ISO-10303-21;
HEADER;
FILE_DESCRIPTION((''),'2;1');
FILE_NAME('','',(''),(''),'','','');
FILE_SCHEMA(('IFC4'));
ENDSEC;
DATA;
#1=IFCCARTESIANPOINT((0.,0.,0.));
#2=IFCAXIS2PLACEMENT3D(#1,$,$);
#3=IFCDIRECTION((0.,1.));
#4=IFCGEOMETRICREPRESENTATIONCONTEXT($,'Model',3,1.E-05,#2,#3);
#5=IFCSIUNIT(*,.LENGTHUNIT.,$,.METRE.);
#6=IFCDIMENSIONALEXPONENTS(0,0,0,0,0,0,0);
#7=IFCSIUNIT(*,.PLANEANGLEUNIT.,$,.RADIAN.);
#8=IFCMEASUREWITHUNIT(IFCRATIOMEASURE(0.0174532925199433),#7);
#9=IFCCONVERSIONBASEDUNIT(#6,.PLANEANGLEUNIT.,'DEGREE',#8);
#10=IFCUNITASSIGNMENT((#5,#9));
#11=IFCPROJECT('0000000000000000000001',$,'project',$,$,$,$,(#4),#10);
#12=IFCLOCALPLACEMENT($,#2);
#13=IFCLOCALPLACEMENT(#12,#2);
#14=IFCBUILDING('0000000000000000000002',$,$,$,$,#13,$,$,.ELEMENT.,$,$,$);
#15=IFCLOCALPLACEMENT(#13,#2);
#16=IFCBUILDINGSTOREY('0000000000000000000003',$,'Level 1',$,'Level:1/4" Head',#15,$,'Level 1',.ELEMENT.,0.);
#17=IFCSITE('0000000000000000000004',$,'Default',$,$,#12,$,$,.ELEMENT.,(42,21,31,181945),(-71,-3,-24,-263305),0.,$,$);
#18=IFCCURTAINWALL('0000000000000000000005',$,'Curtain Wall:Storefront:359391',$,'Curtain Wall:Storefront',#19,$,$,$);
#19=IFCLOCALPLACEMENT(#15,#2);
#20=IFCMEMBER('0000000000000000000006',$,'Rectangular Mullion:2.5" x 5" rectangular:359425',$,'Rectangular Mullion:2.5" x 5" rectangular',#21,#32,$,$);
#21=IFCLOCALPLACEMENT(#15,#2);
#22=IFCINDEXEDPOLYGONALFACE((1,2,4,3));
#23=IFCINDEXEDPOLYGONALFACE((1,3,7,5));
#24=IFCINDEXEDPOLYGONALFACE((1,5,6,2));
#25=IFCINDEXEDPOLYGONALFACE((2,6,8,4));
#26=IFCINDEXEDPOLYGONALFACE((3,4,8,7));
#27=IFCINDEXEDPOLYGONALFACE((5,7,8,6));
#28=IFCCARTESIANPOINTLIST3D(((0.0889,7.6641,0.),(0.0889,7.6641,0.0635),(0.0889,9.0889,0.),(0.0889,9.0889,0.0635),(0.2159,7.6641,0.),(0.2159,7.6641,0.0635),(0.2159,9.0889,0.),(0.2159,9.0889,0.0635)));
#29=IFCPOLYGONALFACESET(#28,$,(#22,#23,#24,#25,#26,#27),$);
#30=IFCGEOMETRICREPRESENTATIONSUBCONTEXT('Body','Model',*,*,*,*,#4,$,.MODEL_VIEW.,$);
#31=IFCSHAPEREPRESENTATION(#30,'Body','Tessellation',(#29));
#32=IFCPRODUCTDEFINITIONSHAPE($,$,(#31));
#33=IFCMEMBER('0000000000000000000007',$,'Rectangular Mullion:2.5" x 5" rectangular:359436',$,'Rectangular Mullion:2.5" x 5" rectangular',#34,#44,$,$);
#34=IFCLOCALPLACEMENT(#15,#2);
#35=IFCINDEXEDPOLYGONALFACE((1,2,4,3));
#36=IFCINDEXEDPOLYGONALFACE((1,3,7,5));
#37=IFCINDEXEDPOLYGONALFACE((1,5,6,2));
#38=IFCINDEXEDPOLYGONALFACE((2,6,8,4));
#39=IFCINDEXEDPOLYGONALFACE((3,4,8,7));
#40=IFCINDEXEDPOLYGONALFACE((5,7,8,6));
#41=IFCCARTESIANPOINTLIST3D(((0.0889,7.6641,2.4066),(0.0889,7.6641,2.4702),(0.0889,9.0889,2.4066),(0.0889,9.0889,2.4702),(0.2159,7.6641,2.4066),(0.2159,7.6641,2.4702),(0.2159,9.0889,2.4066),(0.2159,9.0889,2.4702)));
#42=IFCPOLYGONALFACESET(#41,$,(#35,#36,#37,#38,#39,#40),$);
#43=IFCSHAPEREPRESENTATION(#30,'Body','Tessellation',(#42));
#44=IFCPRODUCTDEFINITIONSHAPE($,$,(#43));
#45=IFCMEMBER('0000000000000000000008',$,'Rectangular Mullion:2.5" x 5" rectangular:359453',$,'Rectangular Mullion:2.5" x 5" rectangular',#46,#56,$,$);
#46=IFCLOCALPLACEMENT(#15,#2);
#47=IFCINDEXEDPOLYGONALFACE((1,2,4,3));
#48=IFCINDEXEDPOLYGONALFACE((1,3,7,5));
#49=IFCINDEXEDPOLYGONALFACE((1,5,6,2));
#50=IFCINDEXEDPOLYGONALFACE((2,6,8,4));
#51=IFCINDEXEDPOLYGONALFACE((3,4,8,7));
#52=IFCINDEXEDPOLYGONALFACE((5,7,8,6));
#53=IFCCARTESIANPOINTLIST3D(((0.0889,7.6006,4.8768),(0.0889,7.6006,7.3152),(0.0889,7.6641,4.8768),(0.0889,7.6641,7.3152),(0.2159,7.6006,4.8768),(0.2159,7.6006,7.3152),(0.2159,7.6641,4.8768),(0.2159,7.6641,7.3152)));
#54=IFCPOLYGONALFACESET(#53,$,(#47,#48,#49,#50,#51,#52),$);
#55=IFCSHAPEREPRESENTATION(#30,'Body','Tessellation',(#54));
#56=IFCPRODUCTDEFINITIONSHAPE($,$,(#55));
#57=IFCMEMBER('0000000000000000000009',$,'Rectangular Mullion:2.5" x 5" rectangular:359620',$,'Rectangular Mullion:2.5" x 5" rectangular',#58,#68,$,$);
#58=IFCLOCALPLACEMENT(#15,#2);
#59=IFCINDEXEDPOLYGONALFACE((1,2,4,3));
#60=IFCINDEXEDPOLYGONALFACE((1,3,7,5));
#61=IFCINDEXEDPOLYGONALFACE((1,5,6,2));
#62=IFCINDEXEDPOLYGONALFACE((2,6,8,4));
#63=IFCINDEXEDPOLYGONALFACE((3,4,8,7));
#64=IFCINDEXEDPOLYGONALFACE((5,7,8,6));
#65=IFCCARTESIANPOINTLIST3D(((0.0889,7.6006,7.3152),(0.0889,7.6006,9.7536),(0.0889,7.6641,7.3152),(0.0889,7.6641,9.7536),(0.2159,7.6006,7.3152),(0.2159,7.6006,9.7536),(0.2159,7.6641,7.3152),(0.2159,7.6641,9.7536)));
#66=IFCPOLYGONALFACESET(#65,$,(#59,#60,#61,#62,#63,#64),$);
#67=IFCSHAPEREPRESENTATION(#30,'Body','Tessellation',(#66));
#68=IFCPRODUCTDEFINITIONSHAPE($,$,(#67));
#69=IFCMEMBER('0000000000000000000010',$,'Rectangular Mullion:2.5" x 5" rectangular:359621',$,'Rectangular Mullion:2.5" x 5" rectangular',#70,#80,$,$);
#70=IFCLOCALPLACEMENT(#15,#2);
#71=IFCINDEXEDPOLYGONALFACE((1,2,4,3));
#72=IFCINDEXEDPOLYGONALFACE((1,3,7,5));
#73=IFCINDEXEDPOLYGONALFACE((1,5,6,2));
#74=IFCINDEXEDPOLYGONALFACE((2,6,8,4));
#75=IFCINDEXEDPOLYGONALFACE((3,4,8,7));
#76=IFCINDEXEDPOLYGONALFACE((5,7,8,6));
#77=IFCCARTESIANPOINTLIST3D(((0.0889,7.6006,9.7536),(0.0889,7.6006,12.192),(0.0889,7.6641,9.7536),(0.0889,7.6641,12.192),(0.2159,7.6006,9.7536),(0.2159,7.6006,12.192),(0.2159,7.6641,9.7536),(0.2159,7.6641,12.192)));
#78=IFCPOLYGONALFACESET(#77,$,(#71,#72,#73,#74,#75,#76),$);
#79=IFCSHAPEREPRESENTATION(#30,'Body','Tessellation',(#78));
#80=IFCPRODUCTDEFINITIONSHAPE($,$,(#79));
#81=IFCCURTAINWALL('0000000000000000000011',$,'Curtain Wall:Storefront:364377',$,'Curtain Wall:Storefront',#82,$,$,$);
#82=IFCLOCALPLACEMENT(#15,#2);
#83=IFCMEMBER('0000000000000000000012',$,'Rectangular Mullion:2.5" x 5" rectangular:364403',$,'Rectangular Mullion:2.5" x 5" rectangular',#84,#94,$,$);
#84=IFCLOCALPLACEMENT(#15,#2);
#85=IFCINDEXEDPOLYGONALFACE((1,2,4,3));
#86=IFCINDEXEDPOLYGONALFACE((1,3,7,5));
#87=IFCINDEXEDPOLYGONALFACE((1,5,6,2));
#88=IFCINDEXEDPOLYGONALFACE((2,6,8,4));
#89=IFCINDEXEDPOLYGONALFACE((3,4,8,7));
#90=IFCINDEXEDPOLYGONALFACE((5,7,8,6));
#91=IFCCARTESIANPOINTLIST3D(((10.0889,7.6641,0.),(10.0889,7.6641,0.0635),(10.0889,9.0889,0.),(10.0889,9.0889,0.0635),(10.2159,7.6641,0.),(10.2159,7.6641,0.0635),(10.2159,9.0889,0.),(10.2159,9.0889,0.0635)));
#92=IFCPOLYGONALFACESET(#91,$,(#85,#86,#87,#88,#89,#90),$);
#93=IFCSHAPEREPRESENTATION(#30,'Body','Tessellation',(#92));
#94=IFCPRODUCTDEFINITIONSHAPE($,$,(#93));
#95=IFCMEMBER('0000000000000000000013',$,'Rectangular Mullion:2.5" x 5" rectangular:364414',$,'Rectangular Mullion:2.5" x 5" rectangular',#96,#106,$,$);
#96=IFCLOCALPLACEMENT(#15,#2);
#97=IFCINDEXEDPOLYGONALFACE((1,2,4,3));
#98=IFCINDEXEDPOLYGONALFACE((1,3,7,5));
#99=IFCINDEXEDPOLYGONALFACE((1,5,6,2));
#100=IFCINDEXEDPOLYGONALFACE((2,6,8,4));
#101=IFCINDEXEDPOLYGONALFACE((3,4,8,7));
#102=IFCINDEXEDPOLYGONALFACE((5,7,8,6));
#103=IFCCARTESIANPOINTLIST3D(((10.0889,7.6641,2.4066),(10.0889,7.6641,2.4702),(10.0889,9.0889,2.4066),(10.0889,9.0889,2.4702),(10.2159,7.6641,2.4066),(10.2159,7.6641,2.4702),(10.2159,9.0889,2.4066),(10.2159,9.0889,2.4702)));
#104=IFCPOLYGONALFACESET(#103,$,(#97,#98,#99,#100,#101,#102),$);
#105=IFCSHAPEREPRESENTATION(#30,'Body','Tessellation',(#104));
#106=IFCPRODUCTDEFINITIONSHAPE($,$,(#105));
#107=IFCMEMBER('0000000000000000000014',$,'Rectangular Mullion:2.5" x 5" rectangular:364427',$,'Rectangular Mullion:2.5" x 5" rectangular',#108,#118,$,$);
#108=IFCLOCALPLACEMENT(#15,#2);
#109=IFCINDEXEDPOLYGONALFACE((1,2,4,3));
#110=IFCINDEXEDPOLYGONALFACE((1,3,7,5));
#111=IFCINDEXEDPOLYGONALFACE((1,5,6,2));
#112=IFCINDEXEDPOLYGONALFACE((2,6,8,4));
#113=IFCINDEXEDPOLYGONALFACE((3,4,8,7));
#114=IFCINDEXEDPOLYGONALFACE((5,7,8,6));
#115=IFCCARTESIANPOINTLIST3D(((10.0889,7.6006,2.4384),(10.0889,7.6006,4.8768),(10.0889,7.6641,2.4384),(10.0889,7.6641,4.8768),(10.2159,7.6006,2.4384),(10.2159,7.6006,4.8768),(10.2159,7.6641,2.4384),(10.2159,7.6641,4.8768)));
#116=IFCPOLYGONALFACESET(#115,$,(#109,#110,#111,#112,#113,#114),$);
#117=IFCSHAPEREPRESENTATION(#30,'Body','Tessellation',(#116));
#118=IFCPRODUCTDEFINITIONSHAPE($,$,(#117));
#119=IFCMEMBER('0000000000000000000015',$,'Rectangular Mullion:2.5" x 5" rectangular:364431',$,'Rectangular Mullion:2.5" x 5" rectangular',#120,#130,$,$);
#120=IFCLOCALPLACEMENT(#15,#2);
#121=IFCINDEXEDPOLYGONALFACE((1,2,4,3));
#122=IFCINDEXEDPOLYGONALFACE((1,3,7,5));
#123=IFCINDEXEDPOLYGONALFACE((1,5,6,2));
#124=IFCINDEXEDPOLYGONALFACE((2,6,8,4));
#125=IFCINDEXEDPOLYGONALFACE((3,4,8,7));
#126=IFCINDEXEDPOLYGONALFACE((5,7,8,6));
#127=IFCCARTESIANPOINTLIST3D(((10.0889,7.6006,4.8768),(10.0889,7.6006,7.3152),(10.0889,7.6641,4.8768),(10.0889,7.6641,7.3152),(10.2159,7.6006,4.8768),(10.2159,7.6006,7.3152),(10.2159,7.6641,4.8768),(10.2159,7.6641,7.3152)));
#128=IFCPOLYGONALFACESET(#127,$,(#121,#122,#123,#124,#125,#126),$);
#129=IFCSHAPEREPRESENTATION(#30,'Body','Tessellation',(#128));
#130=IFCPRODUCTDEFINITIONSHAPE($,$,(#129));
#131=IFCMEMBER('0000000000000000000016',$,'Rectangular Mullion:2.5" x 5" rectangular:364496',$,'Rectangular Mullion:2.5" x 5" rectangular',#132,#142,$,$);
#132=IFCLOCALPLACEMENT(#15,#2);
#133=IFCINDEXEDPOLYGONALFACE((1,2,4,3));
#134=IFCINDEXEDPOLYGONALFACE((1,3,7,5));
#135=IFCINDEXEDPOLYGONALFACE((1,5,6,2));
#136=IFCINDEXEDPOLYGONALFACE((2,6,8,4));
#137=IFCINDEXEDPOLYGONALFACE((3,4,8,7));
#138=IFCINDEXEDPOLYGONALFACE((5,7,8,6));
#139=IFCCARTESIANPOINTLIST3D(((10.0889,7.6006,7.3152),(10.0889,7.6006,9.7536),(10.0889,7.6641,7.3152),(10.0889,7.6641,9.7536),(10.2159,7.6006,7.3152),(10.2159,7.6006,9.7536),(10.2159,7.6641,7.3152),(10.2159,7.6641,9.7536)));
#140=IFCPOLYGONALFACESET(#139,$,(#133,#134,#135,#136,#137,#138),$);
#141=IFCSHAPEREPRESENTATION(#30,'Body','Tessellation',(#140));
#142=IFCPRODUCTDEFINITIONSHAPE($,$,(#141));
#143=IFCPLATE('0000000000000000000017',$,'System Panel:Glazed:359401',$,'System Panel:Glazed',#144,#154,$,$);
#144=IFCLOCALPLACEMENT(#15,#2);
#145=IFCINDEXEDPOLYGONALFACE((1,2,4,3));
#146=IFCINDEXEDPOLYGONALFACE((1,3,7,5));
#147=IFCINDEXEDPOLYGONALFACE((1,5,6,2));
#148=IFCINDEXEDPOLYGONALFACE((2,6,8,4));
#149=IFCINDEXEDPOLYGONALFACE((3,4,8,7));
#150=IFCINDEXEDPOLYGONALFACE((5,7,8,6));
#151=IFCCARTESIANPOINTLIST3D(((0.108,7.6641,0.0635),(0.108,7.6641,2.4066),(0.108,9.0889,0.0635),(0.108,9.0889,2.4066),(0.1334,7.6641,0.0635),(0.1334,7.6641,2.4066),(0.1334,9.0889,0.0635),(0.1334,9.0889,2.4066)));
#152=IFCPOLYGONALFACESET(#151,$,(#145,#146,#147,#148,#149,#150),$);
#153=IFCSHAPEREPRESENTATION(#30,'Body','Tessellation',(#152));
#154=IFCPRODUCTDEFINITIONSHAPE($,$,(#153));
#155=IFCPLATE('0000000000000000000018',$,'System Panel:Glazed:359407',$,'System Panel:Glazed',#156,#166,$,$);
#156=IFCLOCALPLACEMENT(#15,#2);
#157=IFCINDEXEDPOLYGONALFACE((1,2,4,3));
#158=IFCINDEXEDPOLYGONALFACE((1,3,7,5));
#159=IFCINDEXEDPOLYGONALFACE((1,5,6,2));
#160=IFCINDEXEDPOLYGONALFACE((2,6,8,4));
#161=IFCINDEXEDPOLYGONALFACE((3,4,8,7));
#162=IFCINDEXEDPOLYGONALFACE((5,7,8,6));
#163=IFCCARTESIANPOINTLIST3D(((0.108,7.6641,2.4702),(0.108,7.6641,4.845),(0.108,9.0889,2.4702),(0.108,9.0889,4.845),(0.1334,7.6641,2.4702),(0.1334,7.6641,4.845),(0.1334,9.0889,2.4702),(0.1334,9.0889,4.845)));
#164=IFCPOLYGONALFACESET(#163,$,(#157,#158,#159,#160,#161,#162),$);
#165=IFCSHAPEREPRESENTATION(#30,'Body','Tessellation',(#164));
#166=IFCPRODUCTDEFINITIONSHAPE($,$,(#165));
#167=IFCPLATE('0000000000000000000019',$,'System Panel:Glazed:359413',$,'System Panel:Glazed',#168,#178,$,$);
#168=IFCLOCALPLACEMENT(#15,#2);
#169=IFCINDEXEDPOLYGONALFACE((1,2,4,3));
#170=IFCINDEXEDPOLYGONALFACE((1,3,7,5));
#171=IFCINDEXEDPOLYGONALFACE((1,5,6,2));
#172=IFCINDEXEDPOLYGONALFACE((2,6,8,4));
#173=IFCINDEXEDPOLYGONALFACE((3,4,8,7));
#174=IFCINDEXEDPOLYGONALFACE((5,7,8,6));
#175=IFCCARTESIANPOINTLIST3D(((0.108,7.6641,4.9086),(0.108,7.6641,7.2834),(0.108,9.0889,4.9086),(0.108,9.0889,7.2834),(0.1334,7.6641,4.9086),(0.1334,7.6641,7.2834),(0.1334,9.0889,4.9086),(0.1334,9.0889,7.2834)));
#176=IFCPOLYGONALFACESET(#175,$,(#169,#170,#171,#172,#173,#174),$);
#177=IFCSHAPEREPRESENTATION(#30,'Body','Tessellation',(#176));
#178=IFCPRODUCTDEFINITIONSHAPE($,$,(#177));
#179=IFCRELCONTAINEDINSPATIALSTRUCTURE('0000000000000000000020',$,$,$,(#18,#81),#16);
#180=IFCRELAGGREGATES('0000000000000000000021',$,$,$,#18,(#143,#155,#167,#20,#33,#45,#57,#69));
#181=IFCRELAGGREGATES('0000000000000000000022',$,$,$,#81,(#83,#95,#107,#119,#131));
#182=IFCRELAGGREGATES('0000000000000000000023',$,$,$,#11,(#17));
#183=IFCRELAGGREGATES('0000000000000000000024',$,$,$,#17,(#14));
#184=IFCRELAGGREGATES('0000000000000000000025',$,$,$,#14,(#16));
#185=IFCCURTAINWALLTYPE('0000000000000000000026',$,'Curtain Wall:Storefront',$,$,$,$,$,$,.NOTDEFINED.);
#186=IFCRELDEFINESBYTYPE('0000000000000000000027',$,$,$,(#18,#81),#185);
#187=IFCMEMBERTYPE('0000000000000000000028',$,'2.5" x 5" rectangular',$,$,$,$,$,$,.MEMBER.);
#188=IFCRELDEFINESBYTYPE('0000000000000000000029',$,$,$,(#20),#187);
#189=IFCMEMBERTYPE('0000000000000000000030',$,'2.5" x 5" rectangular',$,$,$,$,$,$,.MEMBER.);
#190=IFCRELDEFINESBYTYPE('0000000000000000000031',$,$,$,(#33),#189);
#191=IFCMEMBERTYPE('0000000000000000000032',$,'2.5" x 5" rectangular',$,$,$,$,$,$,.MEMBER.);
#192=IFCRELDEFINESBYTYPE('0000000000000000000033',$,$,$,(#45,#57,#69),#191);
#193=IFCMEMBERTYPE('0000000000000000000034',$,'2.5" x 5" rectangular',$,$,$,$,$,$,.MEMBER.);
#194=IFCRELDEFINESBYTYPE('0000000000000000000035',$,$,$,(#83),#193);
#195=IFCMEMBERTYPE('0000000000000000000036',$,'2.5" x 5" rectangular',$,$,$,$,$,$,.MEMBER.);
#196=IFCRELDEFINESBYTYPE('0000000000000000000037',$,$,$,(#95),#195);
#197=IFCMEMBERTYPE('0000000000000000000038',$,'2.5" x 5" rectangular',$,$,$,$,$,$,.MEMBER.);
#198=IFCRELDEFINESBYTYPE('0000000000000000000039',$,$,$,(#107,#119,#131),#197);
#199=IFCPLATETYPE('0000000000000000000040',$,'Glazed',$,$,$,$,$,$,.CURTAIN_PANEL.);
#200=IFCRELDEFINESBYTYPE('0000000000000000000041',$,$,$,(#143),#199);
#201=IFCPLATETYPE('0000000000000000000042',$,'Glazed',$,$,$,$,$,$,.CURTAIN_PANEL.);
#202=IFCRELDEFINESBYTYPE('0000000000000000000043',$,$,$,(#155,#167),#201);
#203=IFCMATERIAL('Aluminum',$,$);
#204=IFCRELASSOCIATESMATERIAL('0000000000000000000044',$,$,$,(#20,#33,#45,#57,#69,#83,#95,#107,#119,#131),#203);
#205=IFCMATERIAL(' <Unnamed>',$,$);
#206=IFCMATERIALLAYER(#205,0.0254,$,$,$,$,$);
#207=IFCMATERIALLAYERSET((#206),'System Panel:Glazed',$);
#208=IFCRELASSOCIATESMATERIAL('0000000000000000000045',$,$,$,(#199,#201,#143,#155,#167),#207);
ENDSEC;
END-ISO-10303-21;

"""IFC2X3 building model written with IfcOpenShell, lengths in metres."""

from ifc_helpers import new_model, entity, si_unit, converted_unit, direction, frame, frame_2d, origin, origin_2d_with_axis, place, context, subcontext, project, spatial, rectangle, extrude, source, transform, mapped, material, layer, layer_set, layer_usage, type_object, type_shapes, element, aggregate, save


model = new_model("IFC2X3")

# Units and contexts
model_context = context("Model", 3, precision=1e-05, world=origin(), true_north=direction((0.0, 1.0)))
body_context = subcontext(model_context, "Body", "Model", "MODEL_VIEW")
ifc_project = project(units=[si_unit("LENGTHUNIT", "METRE"), converted_unit("PLANEANGLEUNIT", "DEGREE", entity("IfcRatioMeasure", 0.0174532925199433), si_unit("PLANEANGLEUNIT", "RADIAN"), dimensions=[0, 0, 0, 0, 0, 0, 0])], contexts=[model_context])

# Site, building, storey
site_placement = place(None, origin())
site = spatial("IfcSite", under=ifc_project, at=site_placement, Name="Default", CompositionType="ELEMENT", RefLatitude=(42, 21, 31, 181945), RefLongitude=(-71, -3, -24, -263305), RefElevation=0.0)
building_placement = place(site_placement, origin())
building = spatial("IfcBuilding", under=site, at=building_placement, CompositionType="ELEMENT")
storey_placement = place(building_placement, origin())
storey = spatial("IfcBuildingStorey", under=building, at=storey_placement, Name="Level 1", ObjectType="Level:1/4\" Head", LongName="Level 1", CompositionType="ELEMENT", Elevation=0.0)

# Curtain walls, members
curtain_wall_type = type_object("IfcCurtainWallType", Name="Curtain Wall:Storefront", PredefinedType="NOTDEFINED")
curtain_wall_1_placement = place(storey_placement, origin())
curtain_wall_1 = element("IfcCurtainWall", 1, at=curtain_wall_1_placement, inside=storey, type_object=curtain_wall_type, Name="Curtain Wall:Storefront:359391", ObjectType="Curtain Wall:Storefront")
ifc_material_1 = material(Name="Aluminum")
member_type_1 = type_object("IfcMemberType", Name="2.5\" x 5\" rectangular", PredefinedType="MEMBER")
shared_shape_1 = source(origin(), body_context, "Body", "SweptSolid", [
    extrude(rectangle(XDim=0.127, YDim=0.0635, at=origin_2d_with_axis()), frame((-0.0318, 0.0, -1.4248), z_axis=(0.0, 0.0, 1.0), x_axis=(0.0, -1.0, 0.0)), (0.0, 0.0, 1.0), 1.4248),
])
type_shapes(member_type_1, [shared_shape_1])
member_1_placement = place(storey_placement, frame((0.1524, 7.6641, 0.0), z_axis=(0.0, -1.0, 0.0), x_axis=(0.0, 0.0, -1.0)))
member_1 = element("IfcMember", 2, at=member_1_placement, type_object=member_type_1, material=ifc_material_1, Name="Rectangular Mullion:2.5\" x 5\" rectangular:359425", ObjectType="Rectangular Mullion:2.5\" x 5\" rectangular", context=body_context, shape_type="MappedRepresentation", body=[
    mapped(shared_shape_1, transform((0.0, 0.0, 0.0), scale=1.0)),
])
member_type_2 = type_object("IfcMemberType", Name="2.5\" x 5\" rectangular", PredefinedType="MEMBER")
shared_shape_2 = source(origin(), body_context, "Body", "SweptSolid", [
    extrude(rectangle(XDim=0.127, YDim=0.0635, at=origin_2d_with_axis()), frame((0.0, 0.0, -1.4248), z_axis=(0.0, 0.0, 1.0), x_axis=(0.0, -1.0, 0.0)), (0.0, 0.0, 1.0), 1.4248),
])
type_shapes(member_type_2, [shared_shape_2])
member_2_placement = place(storey_placement, frame((0.1524, 9.0889, 2.4384), z_axis=(0.0, 1.0, 0.0), x_axis=(0.0, 0.0, 1.0)))
member_2 = element("IfcMember", 3, at=member_2_placement, type_object=member_type_2, material=ifc_material_1, Name="Rectangular Mullion:2.5\" x 5\" rectangular:359436", ObjectType="Rectangular Mullion:2.5\" x 5\" rectangular", context=body_context, shape_type="MappedRepresentation", body=[
    mapped(shared_shape_2, transform((0.0, 0.0, 0.0), scale=1.0)),
])
member_type_3 = type_object("IfcMemberType", Name="2.5\" x 5\" rectangular", PredefinedType="MEMBER")
shared_shape_3 = source(origin(), body_context, "Body", "SweptSolid", [
    extrude(rectangle(XDim=0.127, YDim=0.0635, at=origin_2d_with_axis()), frame((0.0, 0.0, -2.4384), z_axis=(0.0, 0.0, 1.0), x_axis=(0.0, -1.0, 0.0)), (0.0, 0.0, 1.0), 2.4384),
])
type_shapes(member_type_3, [shared_shape_3])
member_3_placement = place(storey_placement, frame((0.1524, 7.6324, 4.8768), z_axis=(0.0, 0.0, -1.0), x_axis=(0.0, 1.0, 0.0)))
member_3 = element("IfcMember", 4, at=member_3_placement, type_object=member_type_3, material=ifc_material_1, Name="Rectangular Mullion:2.5\" x 5\" rectangular:359453", ObjectType="Rectangular Mullion:2.5\" x 5\" rectangular", context=body_context, shape_type="MappedRepresentation", body=[
    mapped(shared_shape_3, transform((0.0, 0.0, 0.0), scale=1.0)),
])
member_4_placement = place(storey_placement, frame((0.1524, 7.6324, 7.3152), z_axis=(0.0, 0.0, -1.0), x_axis=(0.0, 1.0, 0.0)))
member_4 = element("IfcMember", 5, at=member_4_placement, type_object=member_type_3, material=ifc_material_1, Name="Rectangular Mullion:2.5\" x 5\" rectangular:359620", ObjectType="Rectangular Mullion:2.5\" x 5\" rectangular", context=body_context, shape_type="MappedRepresentation", body=[
    mapped(shared_shape_3, transform((0.0, 0.0, 0.0), scale=1.0)),
])
member_5_placement = place(storey_placement, frame((0.1524, 7.6324, 9.7536), z_axis=(0.0, 0.0, -1.0), x_axis=(0.0, 1.0, 0.0)))
member_5 = element("IfcMember", 6, at=member_5_placement, type_object=member_type_3, material=ifc_material_1, Name="Rectangular Mullion:2.5\" x 5\" rectangular:359621", ObjectType="Rectangular Mullion:2.5\" x 5\" rectangular", context=body_context, shape_type="MappedRepresentation", body=[
    mapped(shared_shape_3, transform((0.0, 0.0, 0.0), scale=1.0)),
])
curtain_wall_2_placement = place(storey_placement, origin())
curtain_wall_2 = element("IfcCurtainWall", 7, at=curtain_wall_2_placement, inside=storey, type_object=curtain_wall_type, Name="Curtain Wall:Storefront:364377", ObjectType="Curtain Wall:Storefront")
member_type_4 = type_object("IfcMemberType", Name="2.5\" x 5\" rectangular", PredefinedType="MEMBER")
shared_shape_4 = source(origin(), body_context, "Body", "SweptSolid", [
    extrude(rectangle(XDim=0.127, YDim=0.0635, at=origin_2d_with_axis()), frame((-0.0318, 0.0, -1.4248), z_axis=(0.0, 0.0, 1.0), x_axis=(0.0, -1.0, 0.0)), (0.0, 0.0, 1.0), 1.4248),
])
type_shapes(member_type_4, [shared_shape_4])
member_6_placement = place(storey_placement, frame((10.1524, 7.6641, 0.0), z_axis=(0.0, -1.0, 0.0), x_axis=(0.0, 0.0, -1.0)))
member_6 = element("IfcMember", 8, at=member_6_placement, type_object=member_type_4, material=ifc_material_1, Name="Rectangular Mullion:2.5\" x 5\" rectangular:364403", ObjectType="Rectangular Mullion:2.5\" x 5\" rectangular", context=body_context, shape_type="MappedRepresentation", body=[
    mapped(shared_shape_4, transform((0.0, 0.0, 0.0), scale=1.0)),
])
member_type_5 = type_object("IfcMemberType", Name="2.5\" x 5\" rectangular", PredefinedType="MEMBER")
shared_shape_5 = source(origin(), body_context, "Body", "SweptSolid", [
    extrude(rectangle(XDim=0.127, YDim=0.0635, at=origin_2d_with_axis()), frame((0.0, 0.0, -1.4248), z_axis=(0.0, 0.0, 1.0), x_axis=(0.0, -1.0, 0.0)), (0.0, 0.0, 1.0), 1.4248),
])
type_shapes(member_type_5, [shared_shape_5])
member_7_placement = place(storey_placement, frame((10.1524, 9.0889, 2.4384), z_axis=(0.0, 1.0, 0.0), x_axis=(0.0, 0.0, 1.0)))
member_7 = element("IfcMember", 9, at=member_7_placement, type_object=member_type_5, material=ifc_material_1, Name="Rectangular Mullion:2.5\" x 5\" rectangular:364414", ObjectType="Rectangular Mullion:2.5\" x 5\" rectangular", context=body_context, shape_type="MappedRepresentation", body=[
    mapped(shared_shape_5, transform((0.0, 0.0, 0.0), scale=1.0)),
])
member_type_6 = type_object("IfcMemberType", Name="2.5\" x 5\" rectangular", PredefinedType="MEMBER")
shared_shape_6 = source(origin(), body_context, "Body", "SweptSolid", [
    extrude(rectangle(XDim=0.127, YDim=0.0635, at=origin_2d_with_axis()), frame((0.0, 0.0, -2.4384), z_axis=(0.0, 0.0, 1.0), x_axis=(0.0, -1.0, 0.0)), (0.0, 0.0, 1.0), 2.4384),
])
type_shapes(member_type_6, [shared_shape_6])
member_8_placement = place(storey_placement, frame((10.1524, 7.6324, 2.4384), z_axis=(0.0, 0.0, -1.0), x_axis=(0.0, 1.0, 0.0)))
member_8 = element("IfcMember", 10, at=member_8_placement, type_object=member_type_6, material=ifc_material_1, Name="Rectangular Mullion:2.5\" x 5\" rectangular:364427", ObjectType="Rectangular Mullion:2.5\" x 5\" rectangular", context=body_context, shape_type="MappedRepresentation", body=[
    mapped(shared_shape_6, transform((0.0, 0.0, 0.0), scale=1.0)),
])
member_9_placement = place(storey_placement, frame((10.1524, 7.6324, 4.8768), z_axis=(0.0, 0.0, -1.0), x_axis=(0.0, 1.0, 0.0)))
member_9 = element("IfcMember", 11, at=member_9_placement, type_object=member_type_6, material=ifc_material_1, Name="Rectangular Mullion:2.5\" x 5\" rectangular:364431", ObjectType="Rectangular Mullion:2.5\" x 5\" rectangular", context=body_context, shape_type="MappedRepresentation", body=[
    mapped(shared_shape_6, transform((0.0, 0.0, 0.0), scale=1.0)),
])
member_10_placement = place(storey_placement, frame((10.1524, 7.6324, 7.3152), z_axis=(0.0, 0.0, -1.0), x_axis=(0.0, 1.0, 0.0)))
member_10 = element("IfcMember", 12, at=member_10_placement, type_object=member_type_6, material=ifc_material_1, Name="Rectangular Mullion:2.5\" x 5\" rectangular:364496", ObjectType="Rectangular Mullion:2.5\" x 5\" rectangular", context=body_context, shape_type="MappedRepresentation", body=[
    mapped(shared_shape_6, transform((0.0, 0.0, 0.0), scale=1.0)),
])

# Plates
ifc_material_2 = material(Name=" <Unnamed>")
ifc_layer = layer(ifc_material_2, 0.0254)
ifc_layer_set = layer_set([ifc_layer], Name="System Panel:Glazed")
ifc_layer_usage_1 = layer_usage(ifc_layer_set, "AXIS3", "POSITIVE", 0.1042)
plate_type_1 = type_object("IfcPlateType", Name="Glazed", PredefinedType="CURTAIN_PANEL", material=ifc_layer_set)
shared_shape_7 = source(origin(), body_context, "Body", "SweptSolid", [
    extrude(rectangle(XDim=0.0254, YDim=1.4248, at=frame_2d((0.0, 0.0), x_axis=(1.0, 0.0))), frame((0.7124, 0.0127, 0.0), z_axis=(0.0, 0.0, 1.0), x_axis=(0.0, 1.0, 0.0)), (0.0, 0.0, 1.0), 2.3432),
])
type_shapes(plate_type_1, [shared_shape_7])
plate_1_placement = place(curtain_wall_1_placement, frame((0.1334, 7.6641, 0.0635), z_axis=(0.0, 0.0, 1.0), x_axis=(0.0, 1.0, 0.0)))
plate_1 = element("IfcPlate", 13, at=plate_1_placement, type_object=plate_type_1, material=ifc_layer_usage_1, Name="System Panel:Glazed:359401", ObjectType="System Panel:Glazed", context=body_context, shape_type="MappedRepresentation", body=[
    mapped(shared_shape_7, transform((0.0, 0.0, 0.0), scale=1.0)),
])
ifc_layer_usage_2 = layer_usage(ifc_layer_set, "AXIS3", "POSITIVE", 0.1042)
plate_type_2 = type_object("IfcPlateType", Name="Glazed", PredefinedType="CURTAIN_PANEL", material=ifc_layer_set)
shared_shape_8 = source(origin(), body_context, "Body", "SweptSolid", [
    extrude(rectangle(XDim=0.0254, YDim=1.4248, at=frame_2d((0.0, 0.0), x_axis=(1.0, 0.0))), frame((0.7124, 0.0127, 0.0), z_axis=(0.0, 0.0, 1.0), x_axis=(0.0, 1.0, 0.0)), (0.0, 0.0, 1.0), 2.3749),
])
type_shapes(plate_type_2, [shared_shape_8])
plate_2_placement = place(curtain_wall_1_placement, frame((0.1334, 7.6641, 2.4701), z_axis=(0.0, 0.0, 1.0), x_axis=(0.0, 1.0, 0.0)))
plate_2 = element("IfcPlate", 14, at=plate_2_placement, type_object=plate_type_2, material=ifc_layer_usage_2, Name="System Panel:Glazed:359407", ObjectType="System Panel:Glazed", context=body_context, shape_type="MappedRepresentation", body=[
    mapped(shared_shape_8, transform((0.0, 0.0, 0.0), scale=1.0)),
])
ifc_layer_usage_3 = layer_usage(ifc_layer_set, "AXIS3", "POSITIVE", 0.1042)
plate_3_placement = place(curtain_wall_1_placement, frame((0.1334, 7.6641, 4.9085), z_axis=(0.0, 0.0, 1.0), x_axis=(0.0, 1.0, 0.0)))
plate_3 = element("IfcPlate", 15, at=plate_3_placement, type_object=plate_type_2, material=ifc_layer_usage_3, Name="System Panel:Glazed:359413", ObjectType="System Panel:Glazed", context=body_context, shape_type="MappedRepresentation", body=[
    mapped(shared_shape_8, transform((0.0, 0.0, 0.0), scale=1.0)),
])
aggregate(curtain_wall_1, [plate_1, plate_2, plate_3, member_1, member_2, member_3, member_4, member_5])
aggregate(curtain_wall_2, [member_6, member_7, member_8, member_9, member_10])

save(model, "model.ifc")
